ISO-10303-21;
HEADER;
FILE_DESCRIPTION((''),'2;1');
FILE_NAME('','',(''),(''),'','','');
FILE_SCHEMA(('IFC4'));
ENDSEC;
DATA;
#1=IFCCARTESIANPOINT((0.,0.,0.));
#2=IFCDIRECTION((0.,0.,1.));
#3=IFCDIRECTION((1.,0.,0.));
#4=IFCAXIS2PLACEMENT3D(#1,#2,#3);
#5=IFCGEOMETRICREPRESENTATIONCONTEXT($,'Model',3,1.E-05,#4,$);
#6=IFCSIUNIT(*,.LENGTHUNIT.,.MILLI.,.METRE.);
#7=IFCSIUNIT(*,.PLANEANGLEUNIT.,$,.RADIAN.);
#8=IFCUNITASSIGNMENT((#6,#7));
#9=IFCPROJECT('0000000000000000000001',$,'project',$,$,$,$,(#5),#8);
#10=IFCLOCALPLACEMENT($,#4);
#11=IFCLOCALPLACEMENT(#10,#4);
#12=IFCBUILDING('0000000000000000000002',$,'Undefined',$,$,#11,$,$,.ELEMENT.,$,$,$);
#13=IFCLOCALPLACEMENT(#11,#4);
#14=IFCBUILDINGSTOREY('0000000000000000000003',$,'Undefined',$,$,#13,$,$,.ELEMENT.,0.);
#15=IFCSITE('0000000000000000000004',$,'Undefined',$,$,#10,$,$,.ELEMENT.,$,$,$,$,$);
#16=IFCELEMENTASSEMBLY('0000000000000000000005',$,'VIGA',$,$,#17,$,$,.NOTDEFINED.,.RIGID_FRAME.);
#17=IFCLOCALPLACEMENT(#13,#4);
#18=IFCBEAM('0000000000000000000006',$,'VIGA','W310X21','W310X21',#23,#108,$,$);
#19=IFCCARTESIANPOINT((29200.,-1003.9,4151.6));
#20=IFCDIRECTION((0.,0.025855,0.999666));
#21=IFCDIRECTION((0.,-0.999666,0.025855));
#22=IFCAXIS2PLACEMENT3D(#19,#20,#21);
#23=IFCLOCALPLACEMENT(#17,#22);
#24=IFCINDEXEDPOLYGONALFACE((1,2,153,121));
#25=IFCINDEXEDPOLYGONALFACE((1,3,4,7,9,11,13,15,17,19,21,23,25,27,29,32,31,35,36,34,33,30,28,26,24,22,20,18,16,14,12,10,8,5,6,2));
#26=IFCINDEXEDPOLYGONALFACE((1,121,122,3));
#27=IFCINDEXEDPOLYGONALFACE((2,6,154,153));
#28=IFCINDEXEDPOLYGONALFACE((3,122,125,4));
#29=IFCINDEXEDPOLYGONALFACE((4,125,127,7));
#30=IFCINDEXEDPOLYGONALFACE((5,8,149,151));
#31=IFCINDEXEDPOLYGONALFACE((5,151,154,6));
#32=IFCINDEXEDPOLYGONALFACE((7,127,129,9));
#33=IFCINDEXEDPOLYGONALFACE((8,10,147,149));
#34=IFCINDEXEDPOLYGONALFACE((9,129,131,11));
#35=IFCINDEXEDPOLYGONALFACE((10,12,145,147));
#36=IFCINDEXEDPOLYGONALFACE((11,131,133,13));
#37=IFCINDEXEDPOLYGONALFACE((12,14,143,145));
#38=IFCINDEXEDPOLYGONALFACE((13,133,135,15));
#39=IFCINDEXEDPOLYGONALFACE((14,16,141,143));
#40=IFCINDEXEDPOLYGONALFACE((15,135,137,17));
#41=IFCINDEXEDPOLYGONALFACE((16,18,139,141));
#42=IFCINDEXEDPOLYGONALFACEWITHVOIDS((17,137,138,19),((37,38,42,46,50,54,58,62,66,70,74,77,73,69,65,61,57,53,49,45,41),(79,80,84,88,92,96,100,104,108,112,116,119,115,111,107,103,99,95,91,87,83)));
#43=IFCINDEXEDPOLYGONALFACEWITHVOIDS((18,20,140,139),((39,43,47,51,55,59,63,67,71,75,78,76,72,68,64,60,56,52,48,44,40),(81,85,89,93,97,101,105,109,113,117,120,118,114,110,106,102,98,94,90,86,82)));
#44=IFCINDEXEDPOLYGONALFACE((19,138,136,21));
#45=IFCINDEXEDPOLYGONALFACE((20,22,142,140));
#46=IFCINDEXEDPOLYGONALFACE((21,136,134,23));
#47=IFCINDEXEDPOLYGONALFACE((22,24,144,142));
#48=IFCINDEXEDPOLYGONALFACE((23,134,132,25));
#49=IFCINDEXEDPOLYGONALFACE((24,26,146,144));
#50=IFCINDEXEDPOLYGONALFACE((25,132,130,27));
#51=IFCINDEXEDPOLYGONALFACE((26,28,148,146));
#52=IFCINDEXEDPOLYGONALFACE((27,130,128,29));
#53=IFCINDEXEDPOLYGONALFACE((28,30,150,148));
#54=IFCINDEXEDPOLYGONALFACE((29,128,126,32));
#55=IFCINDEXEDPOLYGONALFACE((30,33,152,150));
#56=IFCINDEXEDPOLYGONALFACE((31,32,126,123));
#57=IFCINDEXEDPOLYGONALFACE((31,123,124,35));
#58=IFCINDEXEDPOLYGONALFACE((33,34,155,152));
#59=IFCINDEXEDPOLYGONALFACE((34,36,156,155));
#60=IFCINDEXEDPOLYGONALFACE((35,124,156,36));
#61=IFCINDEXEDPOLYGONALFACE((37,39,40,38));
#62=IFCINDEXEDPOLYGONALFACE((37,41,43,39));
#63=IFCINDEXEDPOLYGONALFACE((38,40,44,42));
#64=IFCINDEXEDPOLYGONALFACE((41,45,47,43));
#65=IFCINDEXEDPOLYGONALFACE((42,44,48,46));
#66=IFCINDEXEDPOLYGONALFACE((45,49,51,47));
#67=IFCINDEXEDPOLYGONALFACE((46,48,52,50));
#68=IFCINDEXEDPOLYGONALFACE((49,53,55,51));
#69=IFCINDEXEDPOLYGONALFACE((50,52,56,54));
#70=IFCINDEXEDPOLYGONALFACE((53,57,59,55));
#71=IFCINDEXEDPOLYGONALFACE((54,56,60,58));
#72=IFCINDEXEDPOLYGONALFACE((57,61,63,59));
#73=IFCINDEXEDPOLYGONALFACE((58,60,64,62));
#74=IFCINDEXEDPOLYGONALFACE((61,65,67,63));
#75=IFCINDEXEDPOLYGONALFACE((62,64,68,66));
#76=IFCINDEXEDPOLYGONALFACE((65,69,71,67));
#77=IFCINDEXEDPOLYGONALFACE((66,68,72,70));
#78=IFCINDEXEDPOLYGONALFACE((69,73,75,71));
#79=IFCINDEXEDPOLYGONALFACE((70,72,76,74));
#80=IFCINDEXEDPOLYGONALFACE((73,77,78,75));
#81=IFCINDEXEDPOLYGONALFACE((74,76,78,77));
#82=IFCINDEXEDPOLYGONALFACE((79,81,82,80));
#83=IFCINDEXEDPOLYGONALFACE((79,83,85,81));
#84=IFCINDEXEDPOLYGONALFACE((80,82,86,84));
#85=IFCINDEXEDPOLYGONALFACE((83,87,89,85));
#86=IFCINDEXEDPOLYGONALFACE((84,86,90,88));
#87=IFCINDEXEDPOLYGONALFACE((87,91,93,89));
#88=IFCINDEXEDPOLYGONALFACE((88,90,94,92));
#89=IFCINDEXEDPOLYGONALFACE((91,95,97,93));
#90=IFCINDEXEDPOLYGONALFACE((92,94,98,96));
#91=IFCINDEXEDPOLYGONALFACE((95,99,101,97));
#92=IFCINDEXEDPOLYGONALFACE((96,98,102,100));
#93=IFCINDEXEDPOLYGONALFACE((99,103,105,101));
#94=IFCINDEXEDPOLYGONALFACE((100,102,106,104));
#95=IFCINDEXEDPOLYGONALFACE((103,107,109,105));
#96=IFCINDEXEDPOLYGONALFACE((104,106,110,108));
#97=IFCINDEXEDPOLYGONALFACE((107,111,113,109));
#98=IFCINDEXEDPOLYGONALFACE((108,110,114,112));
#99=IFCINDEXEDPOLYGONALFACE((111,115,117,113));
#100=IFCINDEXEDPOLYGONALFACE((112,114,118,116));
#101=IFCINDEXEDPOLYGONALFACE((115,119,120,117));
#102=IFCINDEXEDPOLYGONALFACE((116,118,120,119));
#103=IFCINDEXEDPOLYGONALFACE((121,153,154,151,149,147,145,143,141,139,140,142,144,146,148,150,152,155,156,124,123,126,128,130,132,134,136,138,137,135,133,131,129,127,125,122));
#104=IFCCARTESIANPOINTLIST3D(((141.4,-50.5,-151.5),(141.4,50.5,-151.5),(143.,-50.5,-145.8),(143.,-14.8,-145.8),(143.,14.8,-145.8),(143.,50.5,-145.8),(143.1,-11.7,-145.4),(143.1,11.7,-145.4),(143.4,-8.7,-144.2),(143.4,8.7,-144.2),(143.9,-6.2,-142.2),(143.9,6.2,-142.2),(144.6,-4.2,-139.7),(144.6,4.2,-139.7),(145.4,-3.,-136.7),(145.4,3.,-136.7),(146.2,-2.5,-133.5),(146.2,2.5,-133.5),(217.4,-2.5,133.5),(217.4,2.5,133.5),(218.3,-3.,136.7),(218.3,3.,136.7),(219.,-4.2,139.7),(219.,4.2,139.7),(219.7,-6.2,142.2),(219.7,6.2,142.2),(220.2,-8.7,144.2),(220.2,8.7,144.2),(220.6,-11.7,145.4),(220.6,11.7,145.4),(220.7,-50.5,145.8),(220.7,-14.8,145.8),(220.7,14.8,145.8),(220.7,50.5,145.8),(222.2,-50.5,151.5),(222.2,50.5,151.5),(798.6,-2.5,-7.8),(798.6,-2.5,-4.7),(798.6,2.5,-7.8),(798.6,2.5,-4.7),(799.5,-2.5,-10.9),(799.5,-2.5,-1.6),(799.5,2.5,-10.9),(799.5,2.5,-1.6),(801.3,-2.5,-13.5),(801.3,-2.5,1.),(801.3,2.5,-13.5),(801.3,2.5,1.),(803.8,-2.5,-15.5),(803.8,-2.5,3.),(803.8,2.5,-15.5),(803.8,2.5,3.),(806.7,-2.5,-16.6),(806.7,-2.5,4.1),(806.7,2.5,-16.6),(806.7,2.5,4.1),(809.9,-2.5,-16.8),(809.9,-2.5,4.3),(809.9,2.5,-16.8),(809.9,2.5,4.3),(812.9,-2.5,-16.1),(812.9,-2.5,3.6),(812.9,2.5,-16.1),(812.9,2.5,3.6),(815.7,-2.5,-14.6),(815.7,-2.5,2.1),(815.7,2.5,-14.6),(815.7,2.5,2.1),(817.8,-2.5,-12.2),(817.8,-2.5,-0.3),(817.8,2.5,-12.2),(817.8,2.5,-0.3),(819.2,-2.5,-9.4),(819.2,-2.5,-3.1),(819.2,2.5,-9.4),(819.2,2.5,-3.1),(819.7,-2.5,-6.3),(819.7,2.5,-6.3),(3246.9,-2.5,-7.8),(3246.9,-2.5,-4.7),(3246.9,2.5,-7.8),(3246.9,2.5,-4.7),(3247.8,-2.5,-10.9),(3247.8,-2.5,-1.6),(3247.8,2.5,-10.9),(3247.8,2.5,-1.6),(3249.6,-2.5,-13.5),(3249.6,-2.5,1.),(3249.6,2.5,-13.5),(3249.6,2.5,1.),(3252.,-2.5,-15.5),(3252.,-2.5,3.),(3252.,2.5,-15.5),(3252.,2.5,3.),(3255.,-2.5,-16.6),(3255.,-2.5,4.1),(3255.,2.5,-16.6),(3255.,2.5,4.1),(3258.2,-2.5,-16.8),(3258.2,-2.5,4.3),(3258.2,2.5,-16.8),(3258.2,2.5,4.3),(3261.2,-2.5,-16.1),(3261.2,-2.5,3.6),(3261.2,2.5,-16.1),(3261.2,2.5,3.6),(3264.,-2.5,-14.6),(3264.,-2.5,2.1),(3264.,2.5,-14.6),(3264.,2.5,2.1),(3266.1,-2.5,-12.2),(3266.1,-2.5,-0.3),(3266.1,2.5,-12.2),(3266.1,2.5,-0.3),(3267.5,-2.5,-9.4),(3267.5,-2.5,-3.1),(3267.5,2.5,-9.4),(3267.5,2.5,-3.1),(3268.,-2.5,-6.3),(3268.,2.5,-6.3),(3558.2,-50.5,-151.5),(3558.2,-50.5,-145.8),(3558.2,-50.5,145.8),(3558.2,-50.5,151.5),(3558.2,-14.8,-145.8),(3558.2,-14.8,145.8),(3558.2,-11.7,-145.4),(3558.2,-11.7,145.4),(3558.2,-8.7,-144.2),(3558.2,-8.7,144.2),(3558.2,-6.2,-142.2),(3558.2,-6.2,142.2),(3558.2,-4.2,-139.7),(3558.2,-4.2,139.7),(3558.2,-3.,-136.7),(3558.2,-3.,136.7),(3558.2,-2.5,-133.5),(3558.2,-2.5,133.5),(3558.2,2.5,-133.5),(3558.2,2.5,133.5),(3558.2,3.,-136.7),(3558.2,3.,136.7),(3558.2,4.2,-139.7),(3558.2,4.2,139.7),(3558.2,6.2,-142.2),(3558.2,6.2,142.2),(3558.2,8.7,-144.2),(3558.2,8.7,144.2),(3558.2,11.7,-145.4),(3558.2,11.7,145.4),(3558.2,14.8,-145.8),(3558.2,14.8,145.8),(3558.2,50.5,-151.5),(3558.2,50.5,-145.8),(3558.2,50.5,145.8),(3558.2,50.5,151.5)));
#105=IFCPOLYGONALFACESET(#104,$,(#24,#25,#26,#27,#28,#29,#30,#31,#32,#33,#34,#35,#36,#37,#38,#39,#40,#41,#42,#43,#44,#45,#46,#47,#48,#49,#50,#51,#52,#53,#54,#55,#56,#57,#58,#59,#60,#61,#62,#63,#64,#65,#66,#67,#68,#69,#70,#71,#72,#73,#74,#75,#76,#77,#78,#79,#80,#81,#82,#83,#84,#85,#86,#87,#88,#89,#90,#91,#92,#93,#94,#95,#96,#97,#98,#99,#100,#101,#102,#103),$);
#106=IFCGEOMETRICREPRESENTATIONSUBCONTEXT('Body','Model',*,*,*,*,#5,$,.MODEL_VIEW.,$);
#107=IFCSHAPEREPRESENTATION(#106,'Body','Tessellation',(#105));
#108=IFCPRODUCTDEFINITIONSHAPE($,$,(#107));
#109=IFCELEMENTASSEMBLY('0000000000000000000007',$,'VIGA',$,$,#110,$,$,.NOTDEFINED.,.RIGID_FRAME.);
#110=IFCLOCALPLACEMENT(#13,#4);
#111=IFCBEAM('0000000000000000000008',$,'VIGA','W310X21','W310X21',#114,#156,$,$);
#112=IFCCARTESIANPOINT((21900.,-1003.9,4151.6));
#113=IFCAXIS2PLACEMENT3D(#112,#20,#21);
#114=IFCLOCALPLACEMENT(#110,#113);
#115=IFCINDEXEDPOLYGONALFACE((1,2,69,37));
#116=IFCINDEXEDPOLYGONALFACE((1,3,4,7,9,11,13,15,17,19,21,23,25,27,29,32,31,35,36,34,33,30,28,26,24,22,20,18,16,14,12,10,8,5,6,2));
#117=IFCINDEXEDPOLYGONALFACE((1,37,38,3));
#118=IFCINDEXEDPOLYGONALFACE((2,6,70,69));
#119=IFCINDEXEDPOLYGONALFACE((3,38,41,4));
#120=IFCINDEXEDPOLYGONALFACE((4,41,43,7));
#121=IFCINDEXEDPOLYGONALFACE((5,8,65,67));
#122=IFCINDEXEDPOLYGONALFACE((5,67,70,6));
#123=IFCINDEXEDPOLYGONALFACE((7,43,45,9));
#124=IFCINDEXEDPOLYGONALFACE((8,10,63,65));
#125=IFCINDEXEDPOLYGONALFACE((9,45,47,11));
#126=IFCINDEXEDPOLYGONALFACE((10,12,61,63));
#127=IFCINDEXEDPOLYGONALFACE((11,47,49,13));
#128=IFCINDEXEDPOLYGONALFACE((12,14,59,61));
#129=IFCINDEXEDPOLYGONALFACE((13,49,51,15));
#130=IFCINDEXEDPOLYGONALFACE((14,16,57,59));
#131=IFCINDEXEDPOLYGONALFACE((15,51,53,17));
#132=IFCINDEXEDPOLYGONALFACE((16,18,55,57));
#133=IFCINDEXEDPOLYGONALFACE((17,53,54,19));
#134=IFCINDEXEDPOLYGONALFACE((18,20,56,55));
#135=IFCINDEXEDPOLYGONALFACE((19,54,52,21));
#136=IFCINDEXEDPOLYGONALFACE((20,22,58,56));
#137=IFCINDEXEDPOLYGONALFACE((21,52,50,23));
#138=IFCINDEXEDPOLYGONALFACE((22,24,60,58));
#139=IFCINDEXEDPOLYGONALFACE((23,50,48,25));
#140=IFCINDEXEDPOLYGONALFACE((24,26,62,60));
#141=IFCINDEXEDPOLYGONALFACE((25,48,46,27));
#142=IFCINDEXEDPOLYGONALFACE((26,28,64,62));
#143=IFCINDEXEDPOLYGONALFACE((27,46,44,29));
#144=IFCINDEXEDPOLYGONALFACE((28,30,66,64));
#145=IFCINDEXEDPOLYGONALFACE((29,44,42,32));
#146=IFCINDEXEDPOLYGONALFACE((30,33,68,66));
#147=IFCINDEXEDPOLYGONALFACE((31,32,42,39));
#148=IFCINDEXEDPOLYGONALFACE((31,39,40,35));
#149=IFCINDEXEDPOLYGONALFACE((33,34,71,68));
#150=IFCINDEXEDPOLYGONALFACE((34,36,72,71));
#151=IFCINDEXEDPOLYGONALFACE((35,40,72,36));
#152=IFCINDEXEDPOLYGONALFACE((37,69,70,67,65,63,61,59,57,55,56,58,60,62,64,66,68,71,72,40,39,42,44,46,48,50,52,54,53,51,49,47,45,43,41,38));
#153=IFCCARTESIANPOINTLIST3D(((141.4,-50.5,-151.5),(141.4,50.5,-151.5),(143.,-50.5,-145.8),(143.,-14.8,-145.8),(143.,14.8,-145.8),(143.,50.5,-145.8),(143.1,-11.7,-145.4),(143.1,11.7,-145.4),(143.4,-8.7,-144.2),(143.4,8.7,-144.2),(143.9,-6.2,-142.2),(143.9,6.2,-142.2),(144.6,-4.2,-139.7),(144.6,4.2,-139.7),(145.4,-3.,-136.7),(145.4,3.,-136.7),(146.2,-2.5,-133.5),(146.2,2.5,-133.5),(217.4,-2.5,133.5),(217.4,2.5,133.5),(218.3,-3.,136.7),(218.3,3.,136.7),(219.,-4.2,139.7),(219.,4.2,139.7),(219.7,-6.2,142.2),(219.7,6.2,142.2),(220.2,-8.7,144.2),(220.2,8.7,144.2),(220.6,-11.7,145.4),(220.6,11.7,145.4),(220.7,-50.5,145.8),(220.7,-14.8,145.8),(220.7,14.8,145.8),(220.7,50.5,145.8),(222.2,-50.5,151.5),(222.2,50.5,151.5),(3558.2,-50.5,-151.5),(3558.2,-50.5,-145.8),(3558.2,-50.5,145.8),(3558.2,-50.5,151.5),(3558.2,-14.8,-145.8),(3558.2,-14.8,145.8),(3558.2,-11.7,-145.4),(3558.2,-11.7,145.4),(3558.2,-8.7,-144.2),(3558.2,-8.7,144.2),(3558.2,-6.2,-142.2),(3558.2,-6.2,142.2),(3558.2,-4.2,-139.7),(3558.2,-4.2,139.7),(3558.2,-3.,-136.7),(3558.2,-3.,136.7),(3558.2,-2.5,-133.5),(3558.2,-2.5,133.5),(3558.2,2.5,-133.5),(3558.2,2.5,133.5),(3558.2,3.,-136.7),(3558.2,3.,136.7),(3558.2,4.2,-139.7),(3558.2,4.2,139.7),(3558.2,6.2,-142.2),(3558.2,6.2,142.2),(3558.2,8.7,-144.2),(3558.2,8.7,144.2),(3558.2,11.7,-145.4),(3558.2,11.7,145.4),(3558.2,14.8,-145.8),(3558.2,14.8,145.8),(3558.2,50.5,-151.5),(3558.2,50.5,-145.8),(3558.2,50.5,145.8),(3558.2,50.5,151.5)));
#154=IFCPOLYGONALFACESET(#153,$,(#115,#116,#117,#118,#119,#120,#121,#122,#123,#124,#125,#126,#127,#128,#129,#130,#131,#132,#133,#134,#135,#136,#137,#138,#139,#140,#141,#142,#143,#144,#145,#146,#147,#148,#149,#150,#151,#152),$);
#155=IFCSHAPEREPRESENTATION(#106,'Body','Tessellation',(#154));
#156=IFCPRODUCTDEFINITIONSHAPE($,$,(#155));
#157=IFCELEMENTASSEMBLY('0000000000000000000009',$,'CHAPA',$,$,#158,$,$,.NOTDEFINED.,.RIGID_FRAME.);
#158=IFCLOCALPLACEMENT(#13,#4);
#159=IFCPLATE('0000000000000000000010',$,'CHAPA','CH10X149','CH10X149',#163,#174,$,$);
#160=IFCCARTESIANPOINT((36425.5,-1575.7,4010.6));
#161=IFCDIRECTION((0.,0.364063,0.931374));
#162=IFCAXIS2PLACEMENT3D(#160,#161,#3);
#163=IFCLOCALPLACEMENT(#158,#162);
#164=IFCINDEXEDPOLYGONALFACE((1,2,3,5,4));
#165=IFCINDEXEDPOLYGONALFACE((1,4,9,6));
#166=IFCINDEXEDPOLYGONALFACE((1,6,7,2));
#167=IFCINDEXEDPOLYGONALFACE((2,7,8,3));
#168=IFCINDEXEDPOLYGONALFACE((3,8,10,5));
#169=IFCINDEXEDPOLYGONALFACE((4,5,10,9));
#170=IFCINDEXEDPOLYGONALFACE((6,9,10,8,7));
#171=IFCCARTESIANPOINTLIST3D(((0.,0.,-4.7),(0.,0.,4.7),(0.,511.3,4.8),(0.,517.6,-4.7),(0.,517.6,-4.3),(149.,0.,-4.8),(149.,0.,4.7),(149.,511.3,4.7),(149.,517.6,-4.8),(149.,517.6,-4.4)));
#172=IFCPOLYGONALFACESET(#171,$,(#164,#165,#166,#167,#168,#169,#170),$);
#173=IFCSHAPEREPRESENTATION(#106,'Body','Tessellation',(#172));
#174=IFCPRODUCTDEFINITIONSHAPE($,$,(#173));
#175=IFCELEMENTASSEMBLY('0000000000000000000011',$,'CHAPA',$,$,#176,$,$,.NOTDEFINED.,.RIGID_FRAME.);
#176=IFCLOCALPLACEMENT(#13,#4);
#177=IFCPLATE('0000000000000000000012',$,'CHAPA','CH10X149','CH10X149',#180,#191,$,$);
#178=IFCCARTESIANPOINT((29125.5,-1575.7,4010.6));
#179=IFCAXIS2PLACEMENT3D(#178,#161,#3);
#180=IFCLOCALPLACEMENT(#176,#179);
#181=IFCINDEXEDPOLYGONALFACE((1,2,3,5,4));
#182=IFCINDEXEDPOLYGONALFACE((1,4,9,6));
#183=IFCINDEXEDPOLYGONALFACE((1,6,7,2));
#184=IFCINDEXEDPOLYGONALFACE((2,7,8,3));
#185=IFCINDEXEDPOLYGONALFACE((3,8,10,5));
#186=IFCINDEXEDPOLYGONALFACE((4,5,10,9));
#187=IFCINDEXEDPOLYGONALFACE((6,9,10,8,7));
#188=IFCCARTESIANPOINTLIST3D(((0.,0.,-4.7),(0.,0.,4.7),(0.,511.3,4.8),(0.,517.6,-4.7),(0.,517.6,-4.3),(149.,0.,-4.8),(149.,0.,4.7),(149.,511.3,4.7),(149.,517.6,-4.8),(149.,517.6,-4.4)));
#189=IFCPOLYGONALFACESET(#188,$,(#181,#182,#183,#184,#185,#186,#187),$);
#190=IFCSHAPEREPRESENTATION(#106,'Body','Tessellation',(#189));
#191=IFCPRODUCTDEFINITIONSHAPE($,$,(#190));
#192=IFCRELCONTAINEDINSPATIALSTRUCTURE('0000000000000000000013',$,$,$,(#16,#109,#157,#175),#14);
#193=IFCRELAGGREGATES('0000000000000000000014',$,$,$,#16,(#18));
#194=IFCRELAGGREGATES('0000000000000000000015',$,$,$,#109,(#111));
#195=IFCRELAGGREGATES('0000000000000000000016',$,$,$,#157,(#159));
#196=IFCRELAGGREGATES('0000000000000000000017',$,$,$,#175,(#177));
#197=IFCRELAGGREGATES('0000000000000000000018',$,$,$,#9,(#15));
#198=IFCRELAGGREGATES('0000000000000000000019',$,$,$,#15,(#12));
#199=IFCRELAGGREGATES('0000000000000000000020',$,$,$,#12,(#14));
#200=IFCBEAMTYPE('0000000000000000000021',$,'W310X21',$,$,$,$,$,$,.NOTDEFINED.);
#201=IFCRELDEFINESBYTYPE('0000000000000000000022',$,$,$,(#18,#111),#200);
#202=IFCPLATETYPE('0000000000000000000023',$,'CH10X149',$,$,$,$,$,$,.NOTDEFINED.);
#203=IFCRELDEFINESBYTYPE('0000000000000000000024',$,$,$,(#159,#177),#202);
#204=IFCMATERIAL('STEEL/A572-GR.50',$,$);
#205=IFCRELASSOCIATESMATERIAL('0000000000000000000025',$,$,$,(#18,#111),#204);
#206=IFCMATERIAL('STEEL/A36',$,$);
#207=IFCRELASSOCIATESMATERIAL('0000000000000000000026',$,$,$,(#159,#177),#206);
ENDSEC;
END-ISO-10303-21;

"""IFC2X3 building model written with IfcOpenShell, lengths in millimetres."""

from ifc_helpers import new_model, si_unit, frame, origin_with_axes, origin_2d_with_axis, place, context, subcontext, project, spatial, polyline, circle, i_section, outline, extrude, boolean, clip, halfspace, material, type_object, element, aggregate, save


model = new_model("IFC2X3")

# Units and contexts
model_context = context("Model", 3, precision=1e-05, world=origin_with_axes())
body_context = subcontext(model_context, "Body", "Model", "MODEL_VIEW")
ifc_project = project(units=[si_unit("LENGTHUNIT", "METRE", prefix="MILLI"), si_unit("PLANEANGLEUNIT", "RADIAN")], contexts=[model_context])

# Site, building, storey
site_placement = place(None, origin_with_axes())
site = spatial("IfcSite", under=ifc_project, at=site_placement, Name="Undefined", CompositionType="ELEMENT")
building_placement = place(site_placement, origin_with_axes())
building = spatial("IfcBuilding", under=site, at=building_placement, Name="Undefined", CompositionType="ELEMENT")
storey_placement = place(building_placement, origin_with_axes())
storey = spatial("IfcBuildingStorey", under=building, at=storey_placement, Name="Undefined", CompositionType="ELEMENT", Elevation=0.0)

# Element assemblies, beams
ifc_material_1 = material(Name="STEEL/A572-GR.50")
assembly_1_placement = place(storey_placement, origin_with_axes())
assembly_1 = element("IfcElementAssembly", 1, at=assembly_1_placement, inside=storey, Name="VIGA", AssemblyPlace="NOTDEFINED", PredefinedType="RIGID_FRAME")
beam_type_1 = type_object("IfcBeamType", Name="W310X21", PredefinedType="NOTDEFINED")
beam_1_placement = place(assembly_1_placement, frame((29200.0, -1003.9, 4151.6), z_axis=(0.0, 0.025855, 0.999666), x_axis=(0.0, -0.999666, 0.025855)))
beam_1 = element("IfcBeam", 2, at=beam_1_placement, type_object=beam_type_1, material=ifc_material_1, Name="VIGA", Description="W310X21", ObjectType="W310X21", context=body_context, shape_type="CSG", body=[
    boolean("DIFFERENCE", boolean("DIFFERENCE", boolean("DIFFERENCE", extrude(i_section(OverallWidth=101.0, OverallDepth=303.0, WebThickness=5.1, FlangeThickness=5.7, FilletRadius=12.3, at=origin_2d_with_axis()), frame((3558.2, 0.0, 0.0), z_axis=(-1.0, 0.0, 0.0), x_axis=(0.0, -1.0, 0.0)), (0.0, 0.0, 1.0), 3558.2), extrude(circle(Radius=10.6, at=origin_2d_with_axis()), frame((809.1, -100.0, -6.3), z_axis=(0.0, 1.0, 0.0), x_axis=(1.0, 0.0, 0.0)), (0.0, 0.0, 1.0), 200.0)), extrude(circle(Radius=10.6, at=origin_2d_with_axis()), frame((3257.4, -100.0, -6.3), z_axis=(0.0, 1.0, 0.0), x_axis=(1.0, 0.0, 0.0)), (0.0, 0.0, 1.0), 200.0)), halfspace(frame((141.4, 50.5, -151.7), z_axis=(-0.966259, 0.0, 0.257573), x_axis=(0.257573, 0.0, 0.966259)), False)),
])
aggregate(assembly_1, [beam_1])
assembly_2_placement = place(storey_placement, origin_with_axes())
assembly_2 = element("IfcElementAssembly", 3, at=assembly_2_placement, inside=storey, Name="VIGA", AssemblyPlace="NOTDEFINED", PredefinedType="RIGID_FRAME")
beam_2_placement = place(assembly_2_placement, frame((21900.0, -1003.9, 4151.6), z_axis=(0.0, 0.025855, 0.999666), x_axis=(0.0, -0.999666, 0.025855)))
beam_2 = element("IfcBeam", 4, at=beam_2_placement, type_object=beam_type_1, material=ifc_material_1, Name="VIGA", Description="W310X21", ObjectType="W310X21", context=body_context, shape_type="Clipping", body=[
    clip(extrude(i_section(OverallWidth=101.0, OverallDepth=303.0, WebThickness=5.1, FlangeThickness=5.7, FilletRadius=12.3, at=origin_2d_with_axis()), frame((3558.2, 0.0, 0.0), z_axis=(-1.0, 0.0, 0.0), x_axis=(0.0, -1.0, 0.0)), (0.0, 0.0, 1.0), 3558.2), halfspace(frame((141.4, 50.5, -151.7), z_axis=(-0.966259, 0.0, 0.257573), x_axis=(0.257573, 0.0, 0.966259)), False)),
])
aggregate(assembly_2, [beam_2])

# Shared definitions
ifc_material_2 = material(Name="STEEL/A36")

# Element assemblies, plates
assembly_3_placement = place(storey_placement, origin_with_axes())
assembly_3 = element("IfcElementAssembly", 5, at=assembly_3_placement, inside=storey, Name="CHAPA", AssemblyPlace="NOTDEFINED", PredefinedType="RIGID_FRAME")
plate_type_1 = type_object("IfcPlateType", Name="CH10X149", PredefinedType="NOTDEFINED")
plate_1_placement = place(assembly_3_placement, frame((36425.5, -1575.7, 4010.6), z_axis=(0.0, 0.364063, 0.931374), x_axis=(1.0, 0.0, 0.0)))
plate_1 = element("IfcPlate", 6, at=plate_1_placement, type_object=plate_type_1, material=ifc_material_2, Name="CHAPA", Description="CH10X149", ObjectType="CH10X149", context=body_context, shape_type="Clipping", body=[
    clip(extrude(outline(polyline([(0.0, 0.0), (149.0, 0.0), (149.0, 517.6), (0.0, 517.6), (0.0, 0.0)])), frame((0.0, 0.0, -4.8), z_axis=(0.0, 0.0, 1.0), x_axis=(1.0, 0.0, 0.0)), (0.0, 0.0, 1.0), 9.5), halfspace(frame((149.0, 517.9, -4.7), z_axis=(0.0, 0.821204, 0.570634), x_axis=(0.0, -0.570634, 0.821204)), False)),
])
aggregate(assembly_3, [plate_1])
assembly_4_placement = place(storey_placement, origin_with_axes())
assembly_4 = element("IfcElementAssembly", 7, at=assembly_4_placement, inside=storey, Name="CHAPA", AssemblyPlace="NOTDEFINED", PredefinedType="RIGID_FRAME")
plate_2_placement = place(assembly_4_placement, frame((29125.5, -1575.7, 4010.6), z_axis=(0.0, 0.364063, 0.931374), x_axis=(1.0, 0.0, 0.0)))
plate_2 = element("IfcPlate", 8, at=plate_2_placement, type_object=plate_type_1, material=ifc_material_2, Name="CHAPA", Description="CH10X149", ObjectType="CH10X149", context=body_context, shape_type="Clipping", body=[
    clip(extrude(outline(polyline([(0.0, 0.0), (149.0, 0.0), (149.0, 517.6), (0.0, 517.6), (0.0, 0.0)])), frame((0.0, 0.0, -4.8), z_axis=(0.0, 0.0, 1.0), x_axis=(1.0, 0.0, 0.0)), (0.0, 0.0, 1.0), 9.5), halfspace(frame((149.0, 517.9, -4.7), z_axis=(0.0, 0.821204, 0.570634), x_axis=(0.0, -0.570634, 0.821204)), False)),
])
aggregate(assembly_4, [plate_2])

save(model, "model.ifc")
